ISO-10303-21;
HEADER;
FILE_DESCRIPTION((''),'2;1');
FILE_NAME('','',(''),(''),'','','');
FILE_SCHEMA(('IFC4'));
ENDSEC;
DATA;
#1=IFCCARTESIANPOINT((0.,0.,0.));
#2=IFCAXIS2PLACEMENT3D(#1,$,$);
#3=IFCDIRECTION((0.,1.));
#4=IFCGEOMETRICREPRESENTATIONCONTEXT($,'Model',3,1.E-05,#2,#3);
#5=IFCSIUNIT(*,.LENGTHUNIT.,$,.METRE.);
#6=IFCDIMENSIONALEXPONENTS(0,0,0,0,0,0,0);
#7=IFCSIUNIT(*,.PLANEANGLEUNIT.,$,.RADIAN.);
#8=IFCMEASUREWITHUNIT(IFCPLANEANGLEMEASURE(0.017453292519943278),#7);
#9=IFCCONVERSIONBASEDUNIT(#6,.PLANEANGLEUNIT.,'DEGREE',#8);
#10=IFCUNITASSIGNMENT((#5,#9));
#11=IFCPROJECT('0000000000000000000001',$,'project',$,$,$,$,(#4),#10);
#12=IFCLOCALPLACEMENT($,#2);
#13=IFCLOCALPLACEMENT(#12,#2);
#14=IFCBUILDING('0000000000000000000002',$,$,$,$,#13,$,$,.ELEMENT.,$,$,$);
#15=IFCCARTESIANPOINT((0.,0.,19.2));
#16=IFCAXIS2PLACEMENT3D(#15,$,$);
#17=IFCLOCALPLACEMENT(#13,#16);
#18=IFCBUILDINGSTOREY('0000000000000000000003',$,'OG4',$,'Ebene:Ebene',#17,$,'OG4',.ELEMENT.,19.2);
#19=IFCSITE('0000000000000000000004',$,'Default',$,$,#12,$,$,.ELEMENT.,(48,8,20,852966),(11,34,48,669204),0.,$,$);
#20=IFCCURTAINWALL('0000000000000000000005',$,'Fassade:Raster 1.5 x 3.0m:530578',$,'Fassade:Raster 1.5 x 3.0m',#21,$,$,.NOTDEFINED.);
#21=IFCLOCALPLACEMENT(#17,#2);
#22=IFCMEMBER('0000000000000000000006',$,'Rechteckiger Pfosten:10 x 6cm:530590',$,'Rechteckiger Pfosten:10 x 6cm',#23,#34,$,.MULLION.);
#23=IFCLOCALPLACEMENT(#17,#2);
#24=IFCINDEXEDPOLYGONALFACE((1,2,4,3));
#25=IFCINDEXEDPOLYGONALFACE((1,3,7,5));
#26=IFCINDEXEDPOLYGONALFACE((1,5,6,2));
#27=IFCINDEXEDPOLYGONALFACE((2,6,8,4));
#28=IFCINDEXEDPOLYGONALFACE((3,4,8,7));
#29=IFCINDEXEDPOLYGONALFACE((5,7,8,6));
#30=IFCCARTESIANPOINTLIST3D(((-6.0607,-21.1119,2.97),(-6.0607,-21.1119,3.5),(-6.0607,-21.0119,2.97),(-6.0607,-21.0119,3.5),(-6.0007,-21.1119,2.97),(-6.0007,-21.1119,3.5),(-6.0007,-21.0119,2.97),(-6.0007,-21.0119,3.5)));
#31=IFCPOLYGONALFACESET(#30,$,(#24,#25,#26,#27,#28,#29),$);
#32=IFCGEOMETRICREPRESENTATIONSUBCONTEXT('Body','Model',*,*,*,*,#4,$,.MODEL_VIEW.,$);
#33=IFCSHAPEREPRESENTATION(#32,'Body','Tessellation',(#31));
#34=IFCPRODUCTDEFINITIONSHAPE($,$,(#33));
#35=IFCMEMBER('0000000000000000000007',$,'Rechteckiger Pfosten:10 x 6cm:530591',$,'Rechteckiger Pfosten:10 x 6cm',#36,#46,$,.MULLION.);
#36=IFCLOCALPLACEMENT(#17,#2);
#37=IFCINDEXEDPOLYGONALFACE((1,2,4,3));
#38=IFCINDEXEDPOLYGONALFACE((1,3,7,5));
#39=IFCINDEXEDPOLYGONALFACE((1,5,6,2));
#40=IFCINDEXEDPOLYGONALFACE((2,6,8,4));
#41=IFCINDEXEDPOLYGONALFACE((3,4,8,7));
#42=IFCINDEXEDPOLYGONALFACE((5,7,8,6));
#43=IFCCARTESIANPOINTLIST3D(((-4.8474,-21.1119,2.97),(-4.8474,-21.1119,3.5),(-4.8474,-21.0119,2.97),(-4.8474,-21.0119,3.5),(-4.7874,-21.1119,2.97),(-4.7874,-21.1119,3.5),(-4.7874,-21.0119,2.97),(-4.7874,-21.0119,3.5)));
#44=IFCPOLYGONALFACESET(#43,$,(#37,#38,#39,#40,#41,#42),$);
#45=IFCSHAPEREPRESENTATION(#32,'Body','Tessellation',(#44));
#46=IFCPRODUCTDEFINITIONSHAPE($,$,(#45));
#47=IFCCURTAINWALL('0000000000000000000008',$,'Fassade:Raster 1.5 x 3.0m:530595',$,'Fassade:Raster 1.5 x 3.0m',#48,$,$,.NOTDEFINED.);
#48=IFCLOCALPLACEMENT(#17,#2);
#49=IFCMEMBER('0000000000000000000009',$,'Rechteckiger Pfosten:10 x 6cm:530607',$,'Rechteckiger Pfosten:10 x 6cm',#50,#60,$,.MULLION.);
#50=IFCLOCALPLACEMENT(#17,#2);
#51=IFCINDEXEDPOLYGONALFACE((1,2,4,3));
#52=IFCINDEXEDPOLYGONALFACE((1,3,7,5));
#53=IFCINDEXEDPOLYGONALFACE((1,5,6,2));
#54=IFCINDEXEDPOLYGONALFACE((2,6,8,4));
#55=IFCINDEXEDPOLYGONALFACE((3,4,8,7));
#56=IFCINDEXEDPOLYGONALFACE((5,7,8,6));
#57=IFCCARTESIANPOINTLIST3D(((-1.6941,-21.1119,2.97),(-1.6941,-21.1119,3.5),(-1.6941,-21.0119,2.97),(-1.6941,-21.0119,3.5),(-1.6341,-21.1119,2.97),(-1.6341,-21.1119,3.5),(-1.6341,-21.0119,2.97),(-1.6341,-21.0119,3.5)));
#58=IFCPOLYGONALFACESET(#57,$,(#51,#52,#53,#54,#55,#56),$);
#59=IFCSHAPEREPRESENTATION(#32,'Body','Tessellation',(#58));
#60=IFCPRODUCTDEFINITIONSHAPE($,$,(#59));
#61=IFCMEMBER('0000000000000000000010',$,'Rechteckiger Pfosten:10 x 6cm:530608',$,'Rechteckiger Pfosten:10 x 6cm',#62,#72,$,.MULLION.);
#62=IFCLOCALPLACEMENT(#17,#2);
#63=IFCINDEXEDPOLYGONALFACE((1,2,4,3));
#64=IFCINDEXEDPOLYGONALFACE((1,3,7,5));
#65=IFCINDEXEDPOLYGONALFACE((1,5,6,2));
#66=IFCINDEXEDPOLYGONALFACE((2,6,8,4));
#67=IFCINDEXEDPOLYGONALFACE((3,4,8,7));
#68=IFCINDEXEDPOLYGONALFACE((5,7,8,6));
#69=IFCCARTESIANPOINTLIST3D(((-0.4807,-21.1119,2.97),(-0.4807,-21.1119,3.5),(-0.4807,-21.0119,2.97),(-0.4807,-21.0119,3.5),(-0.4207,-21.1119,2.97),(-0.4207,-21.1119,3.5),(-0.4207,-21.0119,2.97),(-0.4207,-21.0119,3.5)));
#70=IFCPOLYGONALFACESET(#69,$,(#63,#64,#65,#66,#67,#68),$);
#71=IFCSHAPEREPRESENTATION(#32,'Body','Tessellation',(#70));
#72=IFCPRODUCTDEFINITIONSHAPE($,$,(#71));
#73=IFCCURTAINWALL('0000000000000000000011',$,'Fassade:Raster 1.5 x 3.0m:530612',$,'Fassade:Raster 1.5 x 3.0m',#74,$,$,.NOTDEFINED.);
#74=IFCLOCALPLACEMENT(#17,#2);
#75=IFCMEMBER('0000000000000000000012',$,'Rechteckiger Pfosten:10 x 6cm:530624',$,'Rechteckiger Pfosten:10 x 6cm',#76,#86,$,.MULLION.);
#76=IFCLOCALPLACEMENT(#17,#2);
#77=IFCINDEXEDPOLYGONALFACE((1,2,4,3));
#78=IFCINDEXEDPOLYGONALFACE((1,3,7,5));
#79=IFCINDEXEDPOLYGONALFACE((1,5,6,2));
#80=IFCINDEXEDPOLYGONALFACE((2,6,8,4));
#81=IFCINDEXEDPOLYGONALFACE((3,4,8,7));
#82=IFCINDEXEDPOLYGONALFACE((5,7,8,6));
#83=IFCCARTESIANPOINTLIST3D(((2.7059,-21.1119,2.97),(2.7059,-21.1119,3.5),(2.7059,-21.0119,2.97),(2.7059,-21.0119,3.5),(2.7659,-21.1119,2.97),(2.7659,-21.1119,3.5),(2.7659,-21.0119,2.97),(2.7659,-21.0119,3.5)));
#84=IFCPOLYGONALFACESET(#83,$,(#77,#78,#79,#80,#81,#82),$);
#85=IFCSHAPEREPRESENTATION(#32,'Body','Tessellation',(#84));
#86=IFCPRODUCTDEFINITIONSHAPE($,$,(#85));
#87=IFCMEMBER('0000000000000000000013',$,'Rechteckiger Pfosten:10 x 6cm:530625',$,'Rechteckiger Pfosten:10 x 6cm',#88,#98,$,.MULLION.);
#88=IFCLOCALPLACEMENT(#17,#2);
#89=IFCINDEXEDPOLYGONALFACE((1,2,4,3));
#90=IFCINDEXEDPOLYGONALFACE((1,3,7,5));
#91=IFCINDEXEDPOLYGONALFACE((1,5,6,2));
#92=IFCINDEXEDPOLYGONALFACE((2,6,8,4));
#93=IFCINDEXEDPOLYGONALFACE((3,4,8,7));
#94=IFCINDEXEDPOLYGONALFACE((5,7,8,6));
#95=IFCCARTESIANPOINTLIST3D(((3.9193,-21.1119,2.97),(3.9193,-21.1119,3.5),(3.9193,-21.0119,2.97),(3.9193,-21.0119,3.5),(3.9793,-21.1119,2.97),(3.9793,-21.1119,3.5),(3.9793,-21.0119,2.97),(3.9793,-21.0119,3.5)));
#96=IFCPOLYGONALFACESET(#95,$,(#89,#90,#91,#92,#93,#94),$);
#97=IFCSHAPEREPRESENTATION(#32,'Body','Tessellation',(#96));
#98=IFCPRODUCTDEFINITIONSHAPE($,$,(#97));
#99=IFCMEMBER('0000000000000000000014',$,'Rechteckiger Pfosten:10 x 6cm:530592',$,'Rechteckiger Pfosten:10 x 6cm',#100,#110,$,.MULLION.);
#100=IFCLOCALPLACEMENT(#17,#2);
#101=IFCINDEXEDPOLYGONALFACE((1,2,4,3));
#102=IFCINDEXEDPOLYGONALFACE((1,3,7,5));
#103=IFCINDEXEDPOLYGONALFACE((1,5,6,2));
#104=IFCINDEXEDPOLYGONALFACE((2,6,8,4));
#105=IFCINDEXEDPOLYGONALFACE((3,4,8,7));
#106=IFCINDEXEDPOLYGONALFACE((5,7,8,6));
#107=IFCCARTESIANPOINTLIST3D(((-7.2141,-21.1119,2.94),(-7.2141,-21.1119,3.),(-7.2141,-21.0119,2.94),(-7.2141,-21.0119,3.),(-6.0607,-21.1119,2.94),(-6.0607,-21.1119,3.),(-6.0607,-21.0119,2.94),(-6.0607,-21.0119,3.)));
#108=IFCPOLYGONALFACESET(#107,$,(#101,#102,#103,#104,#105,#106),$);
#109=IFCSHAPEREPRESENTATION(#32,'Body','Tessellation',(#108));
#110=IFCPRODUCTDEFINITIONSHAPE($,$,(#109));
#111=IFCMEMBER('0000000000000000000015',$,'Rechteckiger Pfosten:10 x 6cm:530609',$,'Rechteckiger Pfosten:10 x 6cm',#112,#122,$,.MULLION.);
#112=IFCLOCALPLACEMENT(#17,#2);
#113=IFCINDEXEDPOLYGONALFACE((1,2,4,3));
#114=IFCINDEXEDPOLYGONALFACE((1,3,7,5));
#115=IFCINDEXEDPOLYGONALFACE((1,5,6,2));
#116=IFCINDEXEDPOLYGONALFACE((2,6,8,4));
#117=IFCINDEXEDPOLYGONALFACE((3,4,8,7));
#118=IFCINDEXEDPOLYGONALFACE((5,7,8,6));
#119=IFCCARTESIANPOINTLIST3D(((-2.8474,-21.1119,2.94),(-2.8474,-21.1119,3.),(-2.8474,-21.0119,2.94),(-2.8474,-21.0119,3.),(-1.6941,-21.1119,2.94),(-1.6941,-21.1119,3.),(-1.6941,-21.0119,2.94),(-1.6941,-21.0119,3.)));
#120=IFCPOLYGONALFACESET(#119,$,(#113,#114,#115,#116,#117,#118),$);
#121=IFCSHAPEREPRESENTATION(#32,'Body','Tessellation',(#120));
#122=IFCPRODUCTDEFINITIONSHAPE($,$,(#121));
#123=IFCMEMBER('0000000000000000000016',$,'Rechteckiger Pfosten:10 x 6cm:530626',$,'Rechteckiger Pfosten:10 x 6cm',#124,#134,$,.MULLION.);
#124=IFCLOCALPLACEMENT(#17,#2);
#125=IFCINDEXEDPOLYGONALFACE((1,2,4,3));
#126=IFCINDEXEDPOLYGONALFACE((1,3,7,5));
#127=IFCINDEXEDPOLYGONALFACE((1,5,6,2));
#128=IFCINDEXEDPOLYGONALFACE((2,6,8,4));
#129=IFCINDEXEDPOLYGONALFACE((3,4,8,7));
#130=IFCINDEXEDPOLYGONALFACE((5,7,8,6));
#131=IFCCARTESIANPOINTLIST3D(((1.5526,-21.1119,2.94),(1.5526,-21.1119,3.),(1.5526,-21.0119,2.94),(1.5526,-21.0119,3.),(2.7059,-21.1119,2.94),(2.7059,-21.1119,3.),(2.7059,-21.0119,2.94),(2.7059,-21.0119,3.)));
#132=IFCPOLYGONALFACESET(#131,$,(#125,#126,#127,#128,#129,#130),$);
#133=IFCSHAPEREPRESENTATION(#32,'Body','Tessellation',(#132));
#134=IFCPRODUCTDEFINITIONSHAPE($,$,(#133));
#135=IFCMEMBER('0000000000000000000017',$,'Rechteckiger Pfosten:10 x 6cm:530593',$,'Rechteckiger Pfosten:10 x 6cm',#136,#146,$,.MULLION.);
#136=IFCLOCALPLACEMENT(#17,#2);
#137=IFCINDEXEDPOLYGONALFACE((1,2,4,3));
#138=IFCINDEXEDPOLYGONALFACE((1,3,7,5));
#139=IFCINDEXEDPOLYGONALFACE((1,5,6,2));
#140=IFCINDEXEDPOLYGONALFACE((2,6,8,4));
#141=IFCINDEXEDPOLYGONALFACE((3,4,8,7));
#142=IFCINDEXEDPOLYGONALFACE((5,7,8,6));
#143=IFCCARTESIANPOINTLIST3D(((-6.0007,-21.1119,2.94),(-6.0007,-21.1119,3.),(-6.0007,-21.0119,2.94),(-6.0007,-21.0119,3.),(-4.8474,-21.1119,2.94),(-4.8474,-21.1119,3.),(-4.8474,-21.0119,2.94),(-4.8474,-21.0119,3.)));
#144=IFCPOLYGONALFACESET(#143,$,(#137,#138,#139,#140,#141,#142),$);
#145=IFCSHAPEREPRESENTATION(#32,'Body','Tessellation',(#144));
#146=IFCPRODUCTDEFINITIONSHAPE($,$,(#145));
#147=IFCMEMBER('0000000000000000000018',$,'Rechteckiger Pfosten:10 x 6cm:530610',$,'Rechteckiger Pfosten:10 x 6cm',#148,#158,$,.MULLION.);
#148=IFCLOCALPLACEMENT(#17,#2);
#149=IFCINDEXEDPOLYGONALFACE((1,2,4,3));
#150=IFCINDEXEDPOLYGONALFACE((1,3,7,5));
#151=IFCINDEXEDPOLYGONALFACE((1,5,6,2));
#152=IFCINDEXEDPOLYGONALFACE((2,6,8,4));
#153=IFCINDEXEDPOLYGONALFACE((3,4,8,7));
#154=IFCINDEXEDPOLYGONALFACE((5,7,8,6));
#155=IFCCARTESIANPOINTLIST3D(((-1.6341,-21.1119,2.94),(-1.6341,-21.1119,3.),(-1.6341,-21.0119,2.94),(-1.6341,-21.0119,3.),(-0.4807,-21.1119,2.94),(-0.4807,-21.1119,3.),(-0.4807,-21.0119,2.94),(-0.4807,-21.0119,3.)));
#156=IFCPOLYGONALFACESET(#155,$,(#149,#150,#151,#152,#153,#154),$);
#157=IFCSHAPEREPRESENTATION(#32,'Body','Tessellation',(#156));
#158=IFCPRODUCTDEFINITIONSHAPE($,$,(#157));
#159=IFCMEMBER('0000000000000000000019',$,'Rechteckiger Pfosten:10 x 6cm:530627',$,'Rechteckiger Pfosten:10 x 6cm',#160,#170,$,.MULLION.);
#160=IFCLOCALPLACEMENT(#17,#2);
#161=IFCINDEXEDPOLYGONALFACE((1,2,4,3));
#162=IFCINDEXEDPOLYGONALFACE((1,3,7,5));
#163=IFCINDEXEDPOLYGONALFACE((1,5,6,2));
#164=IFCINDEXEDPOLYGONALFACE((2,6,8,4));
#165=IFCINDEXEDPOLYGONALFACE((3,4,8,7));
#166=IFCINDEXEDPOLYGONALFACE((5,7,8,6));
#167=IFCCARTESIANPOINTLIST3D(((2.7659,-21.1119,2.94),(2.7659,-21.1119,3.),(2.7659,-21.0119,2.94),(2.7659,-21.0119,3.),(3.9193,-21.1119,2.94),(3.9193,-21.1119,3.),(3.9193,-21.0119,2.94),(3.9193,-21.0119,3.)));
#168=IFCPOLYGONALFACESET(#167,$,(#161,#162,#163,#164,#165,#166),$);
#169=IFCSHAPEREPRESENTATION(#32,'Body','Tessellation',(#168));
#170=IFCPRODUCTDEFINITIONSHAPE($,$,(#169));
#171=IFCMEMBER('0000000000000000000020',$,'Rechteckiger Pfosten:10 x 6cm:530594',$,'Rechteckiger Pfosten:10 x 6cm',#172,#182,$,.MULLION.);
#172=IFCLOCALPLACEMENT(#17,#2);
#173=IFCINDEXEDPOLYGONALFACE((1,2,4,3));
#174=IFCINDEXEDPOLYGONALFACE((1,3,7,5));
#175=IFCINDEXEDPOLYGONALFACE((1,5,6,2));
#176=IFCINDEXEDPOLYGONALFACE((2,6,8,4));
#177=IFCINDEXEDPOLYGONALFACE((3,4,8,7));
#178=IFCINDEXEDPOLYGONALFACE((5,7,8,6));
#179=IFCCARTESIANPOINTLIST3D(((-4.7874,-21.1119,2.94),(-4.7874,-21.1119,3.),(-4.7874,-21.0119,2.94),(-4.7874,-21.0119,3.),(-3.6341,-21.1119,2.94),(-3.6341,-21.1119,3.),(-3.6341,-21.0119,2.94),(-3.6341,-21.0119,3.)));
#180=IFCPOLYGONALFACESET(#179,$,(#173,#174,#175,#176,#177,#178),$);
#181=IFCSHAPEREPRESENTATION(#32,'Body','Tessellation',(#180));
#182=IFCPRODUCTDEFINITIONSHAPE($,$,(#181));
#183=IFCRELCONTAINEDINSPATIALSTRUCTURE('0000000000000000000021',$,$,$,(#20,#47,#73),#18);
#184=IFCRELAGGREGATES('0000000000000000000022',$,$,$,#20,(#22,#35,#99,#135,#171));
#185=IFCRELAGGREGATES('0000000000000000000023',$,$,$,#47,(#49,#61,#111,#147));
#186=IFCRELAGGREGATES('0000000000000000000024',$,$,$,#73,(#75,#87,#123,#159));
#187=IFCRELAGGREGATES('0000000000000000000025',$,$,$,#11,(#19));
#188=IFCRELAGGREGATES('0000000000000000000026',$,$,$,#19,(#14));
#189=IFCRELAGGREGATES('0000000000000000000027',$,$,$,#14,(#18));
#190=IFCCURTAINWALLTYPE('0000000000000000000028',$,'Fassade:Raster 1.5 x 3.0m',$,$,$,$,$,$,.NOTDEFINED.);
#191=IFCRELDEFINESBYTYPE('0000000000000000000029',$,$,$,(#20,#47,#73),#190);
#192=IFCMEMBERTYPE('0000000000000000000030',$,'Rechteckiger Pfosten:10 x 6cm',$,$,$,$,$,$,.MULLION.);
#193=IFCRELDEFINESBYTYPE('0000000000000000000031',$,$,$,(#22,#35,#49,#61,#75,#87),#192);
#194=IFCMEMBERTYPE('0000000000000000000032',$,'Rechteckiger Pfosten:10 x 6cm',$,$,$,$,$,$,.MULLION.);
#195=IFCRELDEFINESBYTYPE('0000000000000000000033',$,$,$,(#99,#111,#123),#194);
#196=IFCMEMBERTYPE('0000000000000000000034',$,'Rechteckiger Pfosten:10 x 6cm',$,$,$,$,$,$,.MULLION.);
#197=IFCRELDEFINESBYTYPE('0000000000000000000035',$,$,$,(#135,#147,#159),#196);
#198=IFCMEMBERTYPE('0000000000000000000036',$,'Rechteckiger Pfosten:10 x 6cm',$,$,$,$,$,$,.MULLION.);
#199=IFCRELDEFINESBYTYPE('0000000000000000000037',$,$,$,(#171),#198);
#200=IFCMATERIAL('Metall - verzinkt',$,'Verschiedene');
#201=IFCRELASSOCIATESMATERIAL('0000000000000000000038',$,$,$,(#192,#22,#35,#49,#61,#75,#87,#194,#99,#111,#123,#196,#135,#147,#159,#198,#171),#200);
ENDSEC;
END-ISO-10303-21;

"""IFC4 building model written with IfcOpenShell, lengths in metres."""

from ifc_helpers import new_model, entity, si_unit, converted_unit, direction, frame, origin, place, context, subcontext, project, spatial, indexed_curve, outline, extrude, source, transform, mapped, material, type_object, type_shapes, element, aggregate, save


model = new_model("IFC4")

# Units and contexts
model_context = context("Model", 3, precision=1e-05, world=origin(), true_north=direction((0.0, 1.0)))
body_context = subcontext(model_context, "Body", "Model", "MODEL_VIEW")
ifc_project = project(units=[si_unit("LENGTHUNIT", "METRE"), converted_unit("PLANEANGLEUNIT", "DEGREE", entity("IfcPlaneAngleMeasure", 0.017453292519943278), si_unit("PLANEANGLEUNIT", "RADIAN"), dimensions=[0, 0, 0, 0, 0, 0, 0])], contexts=[model_context])

# Site, building, storey
site_placement = place(None, origin())
site = spatial("IfcSite", under=ifc_project, at=site_placement, Name="Default", CompositionType="ELEMENT", RefLatitude=(48, 8, 20, 852966), RefLongitude=(11, 34, 48, 669204), RefElevation=0.0)
building_placement = place(site_placement, origin())
building = spatial("IfcBuilding", under=site, at=building_placement, CompositionType="ELEMENT")
storey_placement = place(building_placement, frame((0.0, 0.0, 19.2)))
storey = spatial("IfcBuildingStorey", under=building, at=storey_placement, Name="OG4", ObjectType="Ebene:Ebene", LongName="OG4", CompositionType="ELEMENT", Elevation=19.2)

# Curtain walls, members
curtain_wall_type = type_object("IfcCurtainWallType", Name="Fassade:Raster 1.5 x 3.0m", PredefinedType="NOTDEFINED")
curtain_wall_1_placement = place(storey_placement, frame((0.0, 0.0, -19.2)))
curtain_wall_1 = element("IfcCurtainWall", 1, at=curtain_wall_1_placement, inside=storey, type_object=curtain_wall_type, Name="Fassade:Raster 1.5 x 3.0m:530578", ObjectType="Fassade:Raster 1.5 x 3.0m", PredefinedType="NOTDEFINED")
ifc_material_1 = material(Name="Metall - verzinkt", Category="Verschiedene")
member_type_1 = type_object("IfcMemberType", Name="Rechteckiger Pfosten:10 x 6cm", PredefinedType="MULLION", material=ifc_material_1)
shared_shape_1 = source(origin(), body_context, "Body", "SweptSolid", [
    extrude(outline(indexed_curve([(-0.03, -0.05), (0.03, -0.05), (0.03, 0.05), (-0.03, 0.05), (-0.03, -0.05)], self_intersect=False)), frame((0.0, 0.0, -0.53), z_axis=(0.0, 0.0, 1.0), x_axis=(-1.0, 0.0, 0.0)), (0.0, 0.0, 1.0), 0.53),
])
type_shapes(member_type_1, [shared_shape_1])
member_1_placement = place(curtain_wall_1_placement, frame((-6.0307, -21.0619, 22.17), z_axis=(0.0, 0.0, -1.0), x_axis=(1.0, 0.0, 0.0)))
member_1 = element("IfcMember", 2, at=member_1_placement, type_object=member_type_1, material=ifc_material_1, Name="Rechteckiger Pfosten:10 x 6cm:530590", ObjectType="Rechteckiger Pfosten:10 x 6cm", PredefinedType="MULLION", context=body_context, shape_type="MappedRepresentation", body=[
    mapped(shared_shape_1, transform((0.0, 0.0, 0.0), scale=1.0)),
])
member_2_placement = place(curtain_wall_1_placement, frame((-4.8174, -21.0619, 22.17), z_axis=(0.0, 0.0, -1.0), x_axis=(1.0, 0.0, 0.0)))
member_2 = element("IfcMember", 3, at=member_2_placement, type_object=member_type_1, material=ifc_material_1, Name="Rechteckiger Pfosten:10 x 6cm:530591", ObjectType="Rechteckiger Pfosten:10 x 6cm", PredefinedType="MULLION", context=body_context, shape_type="MappedRepresentation", body=[
    mapped(shared_shape_1, transform((0.0, 0.0, 0.0), scale=1.0)),
])
curtain_wall_2_placement = place(storey_placement, frame((0.0, 0.0, -19.2)))
curtain_wall_2 = element("IfcCurtainWall", 4, at=curtain_wall_2_placement, inside=storey, type_object=curtain_wall_type, Name="Fassade:Raster 1.5 x 3.0m:530595", ObjectType="Fassade:Raster 1.5 x 3.0m", PredefinedType="NOTDEFINED")
member_3_placement = place(curtain_wall_2_placement, frame((-1.6641, -21.0619, 22.17), z_axis=(0.0, 0.0, -1.0), x_axis=(1.0, 0.0, 0.0)))
member_3 = element("IfcMember", 5, at=member_3_placement, type_object=member_type_1, material=ifc_material_1, Name="Rechteckiger Pfosten:10 x 6cm:530607", ObjectType="Rechteckiger Pfosten:10 x 6cm", PredefinedType="MULLION", context=body_context, shape_type="MappedRepresentation", body=[
    mapped(shared_shape_1, transform((0.0, 0.0, 0.0), scale=1.0)),
])
member_4_placement = place(curtain_wall_2_placement, frame((-0.4507, -21.0619, 22.17), z_axis=(0.0, 0.0, -1.0), x_axis=(1.0, 0.0, 0.0)))
member_4 = element("IfcMember", 6, at=member_4_placement, type_object=member_type_1, material=ifc_material_1, Name="Rechteckiger Pfosten:10 x 6cm:530608", ObjectType="Rechteckiger Pfosten:10 x 6cm", PredefinedType="MULLION", context=body_context, shape_type="MappedRepresentation", body=[
    mapped(shared_shape_1, transform((0.0, 0.0, 0.0), scale=1.0)),
])
curtain_wall_3_placement = place(storey_placement, frame((0.0, 0.0, -19.2)))
curtain_wall_3 = element("IfcCurtainWall", 7, at=curtain_wall_3_placement, inside=storey, type_object=curtain_wall_type, Name="Fassade:Raster 1.5 x 3.0m:530612", ObjectType="Fassade:Raster 1.5 x 3.0m", PredefinedType="NOTDEFINED")
member_5_placement = place(curtain_wall_3_placement, frame((2.7359, -21.0619, 22.17), z_axis=(0.0, 0.0, -1.0), x_axis=(1.0, 0.0, 0.0)))
member_5 = element("IfcMember", 8, at=member_5_placement, type_object=member_type_1, material=ifc_material_1, Name="Rechteckiger Pfosten:10 x 6cm:530624", ObjectType="Rechteckiger Pfosten:10 x 6cm", PredefinedType="MULLION", context=body_context, shape_type="MappedRepresentation", body=[
    mapped(shared_shape_1, transform((0.0, 0.0, 0.0), scale=1.0)),
])
member_6_placement = place(curtain_wall_3_placement, frame((3.9493, -21.0619, 22.17), z_axis=(0.0, 0.0, -1.0), x_axis=(1.0, 0.0, 0.0)))
member_6 = element("IfcMember", 9, at=member_6_placement, type_object=member_type_1, material=ifc_material_1, Name="Rechteckiger Pfosten:10 x 6cm:530625", ObjectType="Rechteckiger Pfosten:10 x 6cm", PredefinedType="MULLION", context=body_context, shape_type="MappedRepresentation", body=[
    mapped(shared_shape_1, transform((0.0, 0.0, 0.0), scale=1.0)),
])

# Members
member_type_2 = type_object("IfcMemberType", Name="Rechteckiger Pfosten:10 x 6cm", PredefinedType="MULLION", material=ifc_material_1)
shared_shape_2 = source(origin(), body_context, "Body", "SweptSolid", [
    extrude(outline(indexed_curve([(-0.03, -0.05), (0.03, -0.05), (0.03, 0.05), (-0.03, 0.05), (-0.03, -0.05)], self_intersect=False)), frame((0.0, 0.0, -1.1533), z_axis=(0.0, 0.0, 1.0), x_axis=(-1.0, 0.0, 0.0)), (0.0, 0.0, 1.0), 1.1533),
])
type_shapes(member_type_2, [shared_shape_2])
member_7_placement = place(curtain_wall_1_placement, frame((-6.0607, -21.0619, 22.17), z_axis=(1.0, 0.0, 0.0), x_axis=(0.0, 0.0, 1.0)))
member_7 = element("IfcMember", 10, at=member_7_placement, type_object=member_type_2, material=ifc_material_1, Name="Rechteckiger Pfosten:10 x 6cm:530592", ObjectType="Rechteckiger Pfosten:10 x 6cm", PredefinedType="MULLION", context=body_context, shape_type="MappedRepresentation", body=[
    mapped(shared_shape_2, transform((0.0, 0.0, 0.0), scale=1.0)),
])
member_8_placement = place(curtain_wall_2_placement, frame((-1.6941, -21.0619, 22.17), z_axis=(1.0, 0.0, 0.0), x_axis=(0.0, 0.0, 1.0)))
member_8 = element("IfcMember", 11, at=member_8_placement, type_object=member_type_2, material=ifc_material_1, Name="Rechteckiger Pfosten:10 x 6cm:530609", ObjectType="Rechteckiger Pfosten:10 x 6cm", PredefinedType="MULLION", context=body_context, shape_type="MappedRepresentation", body=[
    mapped(shared_shape_2, transform((0.0, 0.0, 0.0), scale=1.0)),
])
member_9_placement = place(curtain_wall_3_placement, frame((2.7059, -21.0619, 22.17), z_axis=(1.0, 0.0, 0.0), x_axis=(0.0, 0.0, 1.0)))
member_9 = element("IfcMember", 12, at=member_9_placement, type_object=member_type_2, material=ifc_material_1, Name="Rechteckiger Pfosten:10 x 6cm:530626", ObjectType="Rechteckiger Pfosten:10 x 6cm", PredefinedType="MULLION", context=body_context, shape_type="MappedRepresentation", body=[
    mapped(shared_shape_2, transform((0.0, 0.0, 0.0), scale=1.0)),
])
member_type_3 = type_object("IfcMemberType", Name="Rechteckiger Pfosten:10 x 6cm", PredefinedType="MULLION", material=ifc_material_1)
shared_shape_3 = source(origin(), body_context, "Body", "SweptSolid", [
    extrude(outline(indexed_curve([(-0.03, -0.05), (0.03, -0.05), (0.03, 0.05), (-0.03, 0.05), (-0.03, -0.05)], self_intersect=False)), frame((0.0, 0.0, -1.1533), z_axis=(0.0, 0.0, 1.0), x_axis=(-1.0, 0.0, 0.0)), (0.0, 0.0, 1.0), 1.1533),
])
type_shapes(member_type_3, [shared_shape_3])
member_10_placement = place(curtain_wall_1_placement, frame((-4.8474, -21.0619, 22.17), z_axis=(1.0, 0.0, 0.0), x_axis=(0.0, 0.0, 1.0)))
member_10 = element("IfcMember", 13, at=member_10_placement, type_object=member_type_3, material=ifc_material_1, Name="Rechteckiger Pfosten:10 x 6cm:530593", ObjectType="Rechteckiger Pfosten:10 x 6cm", PredefinedType="MULLION", context=body_context, shape_type="MappedRepresentation", body=[
    mapped(shared_shape_3, transform((0.0, 0.0, 0.0), scale=1.0)),
])
member_11_placement = place(curtain_wall_2_placement, frame((-0.4807, -21.0619, 22.17), z_axis=(1.0, 0.0, 0.0), x_axis=(0.0, 0.0, 1.0)))
member_11 = element("IfcMember", 14, at=member_11_placement, type_object=member_type_3, material=ifc_material_1, Name="Rechteckiger Pfosten:10 x 6cm:530610", ObjectType="Rechteckiger Pfosten:10 x 6cm", PredefinedType="MULLION", context=body_context, shape_type="MappedRepresentation", body=[
    mapped(shared_shape_3, transform((0.0, 0.0, 0.0), scale=1.0)),
])
member_12_placement = place(curtain_wall_3_placement, frame((3.9193, -21.0619, 22.17), z_axis=(1.0, 0.0, 0.0), x_axis=(0.0, 0.0, 1.0)))
member_12 = element("IfcMember", 15, at=member_12_placement, type_object=member_type_3, material=ifc_material_1, Name="Rechteckiger Pfosten:10 x 6cm:530627", ObjectType="Rechteckiger Pfosten:10 x 6cm", PredefinedType="MULLION", context=body_context, shape_type="MappedRepresentation", body=[
    mapped(shared_shape_3, transform((0.0, 0.0, 0.0), scale=1.0)),
])
member_type_4 = type_object("IfcMemberType", Name="Rechteckiger Pfosten:10 x 6cm", PredefinedType="MULLION", material=ifc_material_1)
shared_shape_4 = source(origin(), body_context, "Body", "SweptSolid", [
    extrude(outline(indexed_curve([(-0.03, -0.05), (0.03, -0.05), (0.03, 0.05), (-0.03, 0.05), (-0.03, -0.05)], self_intersect=False)), frame((0.0, 0.0, -1.1533), z_axis=(0.0, 0.0, 1.0), x_axis=(-1.0, 0.0, 0.0)), (0.0, 0.0, 1.0), 1.1533),
])
type_shapes(member_type_4, [shared_shape_4])
member_13_placement = place(curtain_wall_1_placement, frame((-3.6341, -21.0619, 22.17), z_axis=(1.0, 0.0, 0.0), x_axis=(0.0, 0.0, 1.0)))
member_13 = element("IfcMember", 16, at=member_13_placement, type_object=member_type_4, material=ifc_material_1, Name="Rechteckiger Pfosten:10 x 6cm:530594", ObjectType="Rechteckiger Pfosten:10 x 6cm", PredefinedType="MULLION", context=body_context, shape_type="MappedRepresentation", body=[
    mapped(shared_shape_4, transform((0.0, 0.0, 0.0), scale=1.0)),
])

aggregate(curtain_wall_1, [member_1, member_2, member_7, member_10, member_13])
aggregate(curtain_wall_2, [member_3, member_4, member_8, member_11])
aggregate(curtain_wall_3, [member_5, member_6, member_9, member_12])

save(model, "model.ifc")
